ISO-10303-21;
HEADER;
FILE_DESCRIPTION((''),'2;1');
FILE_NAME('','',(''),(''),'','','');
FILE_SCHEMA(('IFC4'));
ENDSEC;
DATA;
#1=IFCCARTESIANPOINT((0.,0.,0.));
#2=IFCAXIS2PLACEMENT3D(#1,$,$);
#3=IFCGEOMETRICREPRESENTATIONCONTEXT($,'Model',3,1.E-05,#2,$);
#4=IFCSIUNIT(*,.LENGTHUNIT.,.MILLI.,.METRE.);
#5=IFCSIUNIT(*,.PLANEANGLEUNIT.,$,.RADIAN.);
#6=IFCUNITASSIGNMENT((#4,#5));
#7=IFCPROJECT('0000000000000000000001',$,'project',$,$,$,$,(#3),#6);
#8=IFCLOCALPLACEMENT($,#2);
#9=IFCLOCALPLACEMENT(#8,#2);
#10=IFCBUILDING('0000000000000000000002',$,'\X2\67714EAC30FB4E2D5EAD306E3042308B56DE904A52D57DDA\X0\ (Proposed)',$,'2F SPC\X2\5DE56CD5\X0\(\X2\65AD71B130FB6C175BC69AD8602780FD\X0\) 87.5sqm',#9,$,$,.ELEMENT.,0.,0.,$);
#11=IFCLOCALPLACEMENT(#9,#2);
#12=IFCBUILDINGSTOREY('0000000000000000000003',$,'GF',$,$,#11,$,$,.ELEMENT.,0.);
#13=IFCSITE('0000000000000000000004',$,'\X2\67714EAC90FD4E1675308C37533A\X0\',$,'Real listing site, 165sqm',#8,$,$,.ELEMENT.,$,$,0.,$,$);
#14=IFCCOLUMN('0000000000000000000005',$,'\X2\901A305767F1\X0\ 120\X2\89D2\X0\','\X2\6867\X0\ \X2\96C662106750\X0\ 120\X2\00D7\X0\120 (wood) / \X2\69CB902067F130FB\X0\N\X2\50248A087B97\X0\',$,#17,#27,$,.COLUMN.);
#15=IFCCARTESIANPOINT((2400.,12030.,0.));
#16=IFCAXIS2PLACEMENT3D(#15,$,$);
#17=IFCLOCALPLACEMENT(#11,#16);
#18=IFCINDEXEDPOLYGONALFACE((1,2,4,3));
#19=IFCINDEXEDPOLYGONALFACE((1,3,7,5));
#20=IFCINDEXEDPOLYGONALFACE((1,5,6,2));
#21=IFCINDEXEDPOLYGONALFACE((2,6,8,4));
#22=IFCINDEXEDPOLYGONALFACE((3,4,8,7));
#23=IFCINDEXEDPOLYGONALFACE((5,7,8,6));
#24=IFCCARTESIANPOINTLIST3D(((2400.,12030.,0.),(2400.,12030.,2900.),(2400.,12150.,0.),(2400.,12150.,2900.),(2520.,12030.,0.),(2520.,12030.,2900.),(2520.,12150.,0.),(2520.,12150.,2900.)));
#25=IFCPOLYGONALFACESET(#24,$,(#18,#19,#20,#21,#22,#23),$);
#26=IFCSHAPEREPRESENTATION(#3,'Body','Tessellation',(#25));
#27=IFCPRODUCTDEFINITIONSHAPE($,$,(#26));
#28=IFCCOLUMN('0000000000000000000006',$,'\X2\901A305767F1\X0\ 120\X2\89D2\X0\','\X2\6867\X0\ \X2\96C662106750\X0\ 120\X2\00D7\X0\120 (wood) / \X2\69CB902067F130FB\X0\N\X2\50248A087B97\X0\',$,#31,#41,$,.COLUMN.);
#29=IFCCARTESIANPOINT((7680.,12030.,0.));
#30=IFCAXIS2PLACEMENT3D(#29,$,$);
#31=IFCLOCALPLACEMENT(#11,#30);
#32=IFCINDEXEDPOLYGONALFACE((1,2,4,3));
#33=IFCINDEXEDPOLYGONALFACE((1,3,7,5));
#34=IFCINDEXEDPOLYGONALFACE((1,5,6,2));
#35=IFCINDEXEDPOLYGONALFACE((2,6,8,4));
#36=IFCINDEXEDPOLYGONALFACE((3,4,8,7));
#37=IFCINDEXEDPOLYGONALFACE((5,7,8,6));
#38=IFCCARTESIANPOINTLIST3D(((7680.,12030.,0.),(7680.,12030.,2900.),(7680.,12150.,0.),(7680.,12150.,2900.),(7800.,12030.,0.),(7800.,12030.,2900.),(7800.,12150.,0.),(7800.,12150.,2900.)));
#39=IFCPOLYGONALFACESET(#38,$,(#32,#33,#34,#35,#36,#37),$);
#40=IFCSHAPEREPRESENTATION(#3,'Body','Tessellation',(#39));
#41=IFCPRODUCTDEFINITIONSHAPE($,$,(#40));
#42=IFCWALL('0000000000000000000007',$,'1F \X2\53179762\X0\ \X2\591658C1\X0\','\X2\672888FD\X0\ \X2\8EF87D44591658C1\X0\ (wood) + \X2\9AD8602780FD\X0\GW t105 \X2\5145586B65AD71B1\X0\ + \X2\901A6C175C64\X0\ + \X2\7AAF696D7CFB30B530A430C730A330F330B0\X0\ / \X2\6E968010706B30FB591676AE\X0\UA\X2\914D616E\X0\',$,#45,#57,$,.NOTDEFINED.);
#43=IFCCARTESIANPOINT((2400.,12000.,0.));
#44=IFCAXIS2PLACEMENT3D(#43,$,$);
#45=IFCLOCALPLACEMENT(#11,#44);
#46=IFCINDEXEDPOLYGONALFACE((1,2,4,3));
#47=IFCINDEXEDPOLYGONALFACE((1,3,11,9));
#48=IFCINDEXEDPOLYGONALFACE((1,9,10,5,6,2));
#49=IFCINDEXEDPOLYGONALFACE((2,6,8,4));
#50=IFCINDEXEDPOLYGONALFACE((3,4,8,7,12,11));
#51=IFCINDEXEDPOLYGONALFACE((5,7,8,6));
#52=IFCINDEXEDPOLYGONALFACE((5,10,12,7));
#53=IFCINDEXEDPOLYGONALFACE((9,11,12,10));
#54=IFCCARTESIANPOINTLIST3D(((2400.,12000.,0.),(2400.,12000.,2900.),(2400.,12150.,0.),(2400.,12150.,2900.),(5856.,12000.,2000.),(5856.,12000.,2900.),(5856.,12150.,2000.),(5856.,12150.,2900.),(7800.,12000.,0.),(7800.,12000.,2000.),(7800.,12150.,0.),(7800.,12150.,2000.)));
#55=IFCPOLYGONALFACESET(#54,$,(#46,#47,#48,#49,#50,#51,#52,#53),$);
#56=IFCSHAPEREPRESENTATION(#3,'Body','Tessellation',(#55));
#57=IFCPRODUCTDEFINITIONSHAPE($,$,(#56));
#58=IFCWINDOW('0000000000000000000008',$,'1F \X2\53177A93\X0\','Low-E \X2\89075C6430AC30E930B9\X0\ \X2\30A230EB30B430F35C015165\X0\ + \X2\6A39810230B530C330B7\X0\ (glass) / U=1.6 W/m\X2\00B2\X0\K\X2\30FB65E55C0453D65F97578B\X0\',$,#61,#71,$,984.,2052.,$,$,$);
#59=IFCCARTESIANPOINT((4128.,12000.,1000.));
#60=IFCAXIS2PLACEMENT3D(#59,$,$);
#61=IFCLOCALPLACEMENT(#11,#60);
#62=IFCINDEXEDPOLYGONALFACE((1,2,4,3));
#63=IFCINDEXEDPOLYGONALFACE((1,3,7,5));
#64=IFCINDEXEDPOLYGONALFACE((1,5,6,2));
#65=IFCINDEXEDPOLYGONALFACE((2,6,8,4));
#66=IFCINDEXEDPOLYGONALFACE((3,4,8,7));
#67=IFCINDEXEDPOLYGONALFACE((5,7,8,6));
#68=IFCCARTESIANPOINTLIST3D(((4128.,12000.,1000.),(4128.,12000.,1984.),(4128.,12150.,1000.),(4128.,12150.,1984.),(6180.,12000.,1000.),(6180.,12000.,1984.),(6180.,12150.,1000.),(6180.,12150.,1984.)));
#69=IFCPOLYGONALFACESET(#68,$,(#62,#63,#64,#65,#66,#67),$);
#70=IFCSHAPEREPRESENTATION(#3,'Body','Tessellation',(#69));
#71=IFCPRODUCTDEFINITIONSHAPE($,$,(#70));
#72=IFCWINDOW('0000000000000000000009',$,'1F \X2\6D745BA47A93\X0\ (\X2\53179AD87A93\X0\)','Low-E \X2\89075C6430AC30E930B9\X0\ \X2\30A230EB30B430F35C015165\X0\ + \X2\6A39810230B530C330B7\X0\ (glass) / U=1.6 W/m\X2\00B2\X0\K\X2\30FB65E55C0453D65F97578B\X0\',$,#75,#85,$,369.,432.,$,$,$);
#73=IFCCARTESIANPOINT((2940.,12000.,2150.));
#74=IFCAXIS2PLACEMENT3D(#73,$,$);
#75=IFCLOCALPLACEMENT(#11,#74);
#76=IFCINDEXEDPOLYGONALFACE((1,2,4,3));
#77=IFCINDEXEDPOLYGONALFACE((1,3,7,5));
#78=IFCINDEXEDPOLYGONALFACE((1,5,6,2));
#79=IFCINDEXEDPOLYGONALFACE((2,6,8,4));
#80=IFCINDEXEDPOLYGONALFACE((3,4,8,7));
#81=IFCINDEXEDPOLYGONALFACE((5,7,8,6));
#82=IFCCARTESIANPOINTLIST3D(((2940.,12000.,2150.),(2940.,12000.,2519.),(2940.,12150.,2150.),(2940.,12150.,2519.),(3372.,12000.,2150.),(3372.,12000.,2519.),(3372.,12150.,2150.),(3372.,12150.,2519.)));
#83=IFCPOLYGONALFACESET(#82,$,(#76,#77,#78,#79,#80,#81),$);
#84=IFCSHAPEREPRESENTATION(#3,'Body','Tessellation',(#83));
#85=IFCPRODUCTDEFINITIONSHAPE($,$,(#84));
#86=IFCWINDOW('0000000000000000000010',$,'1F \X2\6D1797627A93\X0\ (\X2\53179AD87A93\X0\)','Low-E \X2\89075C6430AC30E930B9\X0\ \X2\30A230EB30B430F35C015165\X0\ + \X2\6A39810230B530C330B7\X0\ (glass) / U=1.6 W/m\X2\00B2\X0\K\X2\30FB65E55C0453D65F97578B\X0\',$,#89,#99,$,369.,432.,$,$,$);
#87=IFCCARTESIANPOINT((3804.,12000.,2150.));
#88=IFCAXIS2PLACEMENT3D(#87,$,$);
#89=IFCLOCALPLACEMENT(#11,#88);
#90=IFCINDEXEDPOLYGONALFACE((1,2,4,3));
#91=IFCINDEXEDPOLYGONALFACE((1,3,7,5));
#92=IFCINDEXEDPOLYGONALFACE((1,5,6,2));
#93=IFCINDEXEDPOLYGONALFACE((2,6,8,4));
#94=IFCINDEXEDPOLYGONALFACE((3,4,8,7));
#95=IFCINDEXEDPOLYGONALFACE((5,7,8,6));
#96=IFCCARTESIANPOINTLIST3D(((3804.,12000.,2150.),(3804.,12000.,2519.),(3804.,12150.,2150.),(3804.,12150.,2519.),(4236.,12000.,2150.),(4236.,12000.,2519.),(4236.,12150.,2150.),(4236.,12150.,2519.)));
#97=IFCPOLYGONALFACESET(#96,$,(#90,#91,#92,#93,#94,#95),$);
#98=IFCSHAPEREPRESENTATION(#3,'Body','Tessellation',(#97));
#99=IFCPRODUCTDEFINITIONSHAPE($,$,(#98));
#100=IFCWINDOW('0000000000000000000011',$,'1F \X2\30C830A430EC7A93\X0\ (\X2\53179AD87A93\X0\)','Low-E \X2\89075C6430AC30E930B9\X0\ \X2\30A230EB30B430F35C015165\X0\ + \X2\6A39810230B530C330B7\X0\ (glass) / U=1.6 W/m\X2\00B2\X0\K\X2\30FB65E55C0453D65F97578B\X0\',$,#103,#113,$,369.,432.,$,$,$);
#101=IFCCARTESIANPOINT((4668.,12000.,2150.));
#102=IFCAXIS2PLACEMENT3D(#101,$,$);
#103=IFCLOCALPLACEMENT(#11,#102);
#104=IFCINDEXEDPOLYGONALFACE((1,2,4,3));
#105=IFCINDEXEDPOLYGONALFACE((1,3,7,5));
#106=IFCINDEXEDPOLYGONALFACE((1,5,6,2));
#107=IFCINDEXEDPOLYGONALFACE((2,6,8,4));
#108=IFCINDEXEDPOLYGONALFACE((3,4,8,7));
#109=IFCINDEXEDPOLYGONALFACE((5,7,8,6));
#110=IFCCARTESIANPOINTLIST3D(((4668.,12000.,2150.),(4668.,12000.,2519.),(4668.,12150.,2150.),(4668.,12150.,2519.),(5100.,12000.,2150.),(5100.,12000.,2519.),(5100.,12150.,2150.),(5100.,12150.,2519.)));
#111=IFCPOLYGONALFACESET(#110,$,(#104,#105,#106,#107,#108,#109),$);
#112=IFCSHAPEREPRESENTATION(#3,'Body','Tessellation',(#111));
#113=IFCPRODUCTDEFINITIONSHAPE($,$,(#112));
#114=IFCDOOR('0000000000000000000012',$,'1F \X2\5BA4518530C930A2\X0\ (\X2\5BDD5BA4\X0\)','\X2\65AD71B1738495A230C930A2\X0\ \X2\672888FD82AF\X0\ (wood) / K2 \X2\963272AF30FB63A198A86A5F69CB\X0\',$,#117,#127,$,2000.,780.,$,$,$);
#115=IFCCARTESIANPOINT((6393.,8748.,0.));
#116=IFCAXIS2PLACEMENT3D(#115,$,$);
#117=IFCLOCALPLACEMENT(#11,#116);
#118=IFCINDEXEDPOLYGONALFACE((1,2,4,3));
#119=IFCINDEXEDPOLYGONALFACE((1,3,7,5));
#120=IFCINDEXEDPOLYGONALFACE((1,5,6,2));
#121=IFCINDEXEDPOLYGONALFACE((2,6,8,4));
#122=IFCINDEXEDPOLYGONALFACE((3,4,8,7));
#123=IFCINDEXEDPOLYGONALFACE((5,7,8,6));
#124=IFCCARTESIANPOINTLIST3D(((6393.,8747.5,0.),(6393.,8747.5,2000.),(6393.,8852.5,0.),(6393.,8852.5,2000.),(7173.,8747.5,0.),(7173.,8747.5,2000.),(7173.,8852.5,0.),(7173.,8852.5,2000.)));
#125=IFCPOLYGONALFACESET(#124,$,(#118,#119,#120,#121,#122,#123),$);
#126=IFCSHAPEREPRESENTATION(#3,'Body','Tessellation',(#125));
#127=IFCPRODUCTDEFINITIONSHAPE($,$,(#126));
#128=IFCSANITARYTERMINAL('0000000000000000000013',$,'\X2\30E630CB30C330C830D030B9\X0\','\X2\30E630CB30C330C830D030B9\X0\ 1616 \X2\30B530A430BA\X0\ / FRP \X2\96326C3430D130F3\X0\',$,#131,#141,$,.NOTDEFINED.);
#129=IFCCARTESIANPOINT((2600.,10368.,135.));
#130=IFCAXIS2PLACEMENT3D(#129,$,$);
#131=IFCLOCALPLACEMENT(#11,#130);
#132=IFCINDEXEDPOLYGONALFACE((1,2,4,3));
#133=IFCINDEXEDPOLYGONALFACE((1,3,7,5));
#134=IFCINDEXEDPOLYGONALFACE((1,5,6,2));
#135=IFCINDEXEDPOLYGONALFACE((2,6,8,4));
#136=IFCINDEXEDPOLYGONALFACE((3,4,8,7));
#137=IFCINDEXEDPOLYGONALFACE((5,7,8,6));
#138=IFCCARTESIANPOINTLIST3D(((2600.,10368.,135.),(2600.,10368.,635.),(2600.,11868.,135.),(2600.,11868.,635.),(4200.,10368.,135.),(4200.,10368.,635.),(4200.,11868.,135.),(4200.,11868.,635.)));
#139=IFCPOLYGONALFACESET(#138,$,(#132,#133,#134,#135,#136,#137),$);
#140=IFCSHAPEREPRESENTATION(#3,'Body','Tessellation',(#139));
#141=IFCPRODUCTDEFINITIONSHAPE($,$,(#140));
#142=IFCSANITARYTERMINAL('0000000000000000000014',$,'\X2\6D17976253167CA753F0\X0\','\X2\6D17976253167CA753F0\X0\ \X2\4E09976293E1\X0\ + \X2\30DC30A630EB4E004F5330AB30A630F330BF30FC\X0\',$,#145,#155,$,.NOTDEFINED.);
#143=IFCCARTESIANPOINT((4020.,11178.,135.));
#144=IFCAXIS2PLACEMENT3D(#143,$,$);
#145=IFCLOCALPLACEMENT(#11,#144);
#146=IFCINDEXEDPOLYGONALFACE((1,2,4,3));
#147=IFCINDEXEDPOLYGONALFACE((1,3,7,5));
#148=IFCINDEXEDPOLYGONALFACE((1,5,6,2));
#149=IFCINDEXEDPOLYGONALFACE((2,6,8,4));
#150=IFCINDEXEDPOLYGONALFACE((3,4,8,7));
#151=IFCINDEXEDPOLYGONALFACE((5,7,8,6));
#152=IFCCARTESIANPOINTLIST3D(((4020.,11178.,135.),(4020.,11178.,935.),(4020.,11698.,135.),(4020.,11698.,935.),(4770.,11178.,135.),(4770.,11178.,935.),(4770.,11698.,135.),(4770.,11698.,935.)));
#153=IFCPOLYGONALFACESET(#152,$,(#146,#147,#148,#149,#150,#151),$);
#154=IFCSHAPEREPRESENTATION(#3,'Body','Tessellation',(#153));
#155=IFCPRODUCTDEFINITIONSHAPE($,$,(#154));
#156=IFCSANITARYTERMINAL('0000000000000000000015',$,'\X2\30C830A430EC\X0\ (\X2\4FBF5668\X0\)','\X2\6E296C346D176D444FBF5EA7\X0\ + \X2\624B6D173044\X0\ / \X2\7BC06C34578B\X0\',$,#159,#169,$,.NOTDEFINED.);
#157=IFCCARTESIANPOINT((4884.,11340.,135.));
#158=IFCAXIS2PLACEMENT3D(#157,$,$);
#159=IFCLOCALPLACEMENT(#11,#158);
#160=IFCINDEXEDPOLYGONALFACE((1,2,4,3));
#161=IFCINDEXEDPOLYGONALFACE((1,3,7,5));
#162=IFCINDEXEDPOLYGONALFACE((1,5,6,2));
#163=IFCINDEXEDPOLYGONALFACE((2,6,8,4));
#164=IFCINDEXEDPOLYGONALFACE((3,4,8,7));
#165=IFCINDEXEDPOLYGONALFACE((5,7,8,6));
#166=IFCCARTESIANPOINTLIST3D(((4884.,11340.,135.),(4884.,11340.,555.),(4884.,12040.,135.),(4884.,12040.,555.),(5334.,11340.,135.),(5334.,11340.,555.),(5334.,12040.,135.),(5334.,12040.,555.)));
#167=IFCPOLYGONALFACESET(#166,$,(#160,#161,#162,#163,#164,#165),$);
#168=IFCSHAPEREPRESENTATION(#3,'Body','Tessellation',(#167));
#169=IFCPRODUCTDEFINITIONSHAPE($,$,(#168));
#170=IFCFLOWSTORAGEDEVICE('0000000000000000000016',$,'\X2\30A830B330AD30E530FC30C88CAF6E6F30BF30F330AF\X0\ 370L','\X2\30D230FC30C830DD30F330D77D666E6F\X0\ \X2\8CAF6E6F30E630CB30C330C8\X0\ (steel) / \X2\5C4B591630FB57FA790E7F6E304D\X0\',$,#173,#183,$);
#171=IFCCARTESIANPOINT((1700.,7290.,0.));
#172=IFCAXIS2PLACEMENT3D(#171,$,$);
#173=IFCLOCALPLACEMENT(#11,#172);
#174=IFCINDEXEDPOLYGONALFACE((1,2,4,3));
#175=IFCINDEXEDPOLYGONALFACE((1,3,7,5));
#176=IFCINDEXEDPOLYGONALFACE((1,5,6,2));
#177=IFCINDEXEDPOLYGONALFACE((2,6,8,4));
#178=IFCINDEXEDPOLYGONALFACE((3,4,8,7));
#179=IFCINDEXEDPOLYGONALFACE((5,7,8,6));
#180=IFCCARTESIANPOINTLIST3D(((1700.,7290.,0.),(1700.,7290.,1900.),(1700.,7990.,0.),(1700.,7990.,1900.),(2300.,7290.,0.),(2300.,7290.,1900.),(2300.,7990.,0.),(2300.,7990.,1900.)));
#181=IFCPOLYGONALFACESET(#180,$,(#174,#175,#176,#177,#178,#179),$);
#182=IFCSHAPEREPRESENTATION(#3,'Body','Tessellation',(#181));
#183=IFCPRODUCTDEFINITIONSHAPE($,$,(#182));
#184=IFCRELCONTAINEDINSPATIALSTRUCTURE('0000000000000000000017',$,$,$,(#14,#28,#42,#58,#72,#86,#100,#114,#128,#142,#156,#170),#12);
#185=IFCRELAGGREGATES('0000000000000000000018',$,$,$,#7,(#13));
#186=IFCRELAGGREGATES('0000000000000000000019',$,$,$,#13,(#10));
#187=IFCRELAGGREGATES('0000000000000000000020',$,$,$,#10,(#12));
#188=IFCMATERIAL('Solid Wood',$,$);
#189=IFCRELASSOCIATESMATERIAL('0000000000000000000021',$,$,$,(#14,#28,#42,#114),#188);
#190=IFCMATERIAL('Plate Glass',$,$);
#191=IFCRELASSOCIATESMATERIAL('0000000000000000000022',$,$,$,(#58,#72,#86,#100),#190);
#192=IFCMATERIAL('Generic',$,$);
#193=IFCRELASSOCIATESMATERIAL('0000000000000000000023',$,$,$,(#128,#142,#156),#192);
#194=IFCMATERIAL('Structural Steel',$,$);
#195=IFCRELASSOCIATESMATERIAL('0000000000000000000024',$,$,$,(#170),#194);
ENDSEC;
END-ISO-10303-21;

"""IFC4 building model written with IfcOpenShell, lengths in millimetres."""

from ifc_helpers import new_model, si_unit, frame, frame_2d, origin, place, context, project, spatial, rectangle, extrude, material, element, fill, save


model = new_model("IFC4")

# Units and contexts
model_context = context("Model", 3, precision=1e-05, world=origin())
ifc_project = project(units=[si_unit("LENGTHUNIT", "METRE", prefix="MILLI"), si_unit("PLANEANGLEUNIT", "RADIAN")], contexts=[model_context])

# Site, building, storey
site_placement = place(None, origin())
site = spatial("IfcSite", under=ifc_project, at=site_placement, Name="東京都世田谷区", ObjectType="Real listing site, 165sqm", CompositionType="ELEMENT", RefElevation=0.0)
building_placement = place(site_placement, origin())
building = spatial("IfcBuilding", under=site, at=building_placement, Name="東京・中庭のある回遊動線 (Proposed)", ObjectType="2F SPC工法(断熱・気密高性能) 87.5sqm", CompositionType="ELEMENT", ElevationOfRefHeight=0.0, ElevationOfTerrain=0.0)
storey_placement = place(building_placement, origin())
storey = spatial("IfcBuildingStorey", under=building, at=storey_placement, Name="GF", CompositionType="ELEMENT", Elevation=0.0)

# Columns
ifc_material_1 = material(Name="Solid Wood")
column_1_placement = place(storey_placement, frame((2400.0, 12030.0, 0.0)))
element("IfcColumn", 1, at=column_1_placement, inside=storey, material=ifc_material_1, Name="通し柱 120角", Description="桧 集成材 120×120 (wood) / 構造柱・N値計算", PredefinedType="COLUMN", context=model_context, shape_type="SweptSolid", body=[
    extrude(rectangle(XDim=120.0, YDim=120.0, at=frame_2d((60.0, 60.0))), frame((2400.0, 12030.0, 0.0)), (0.0, 0.0, 1.0), 2900.0),
])
column_2_placement = place(storey_placement, frame((7680.0, 12030.0, 0.0)))
element("IfcColumn", 2, at=column_2_placement, inside=storey, material=ifc_material_1, Name="通し柱 120角", Description="桧 集成材 120×120 (wood) / 構造柱・N値計算", PredefinedType="COLUMN", context=model_context, shape_type="SweptSolid", body=[
    extrude(rectangle(XDim=120.0, YDim=120.0, at=frame_2d((60.0, 60.0))), frame((7680.0, 12030.0, 0.0)), (0.0, 0.0, 1.0), 2900.0),
])

# Wall, openings, windows
wall_1_placement = place(storey_placement, frame((2400.0, 12000.0, 0.0)))
wall_1 = element("IfcWall", 3, at=wall_1_placement, inside=storey, material=ifc_material_1, Name="1F 北面 外壁", Description="木製 軸組外壁 (wood) + 高性能GW t105 充填断熱 + 通気層 + 窯業系サイディング / 準耐火・外皮UA配慮", PredefinedType="NOTDEFINED", context=model_context, shape_type="SweptSolid", body=[
    extrude(rectangle(XDim=5400.0, YDim=150.0, at=frame_2d((2700.0, 75.0))), frame((2400.0, 12000.0, 0.0)), (0.0, 0.0, 1.0), 2900.0),
])
opening_1_placement = place(storey_placement, frame((4128.0, 12000.0, 1000.0)))
opening_1 = element("IfcOpeningElement", 4, at=opening_1_placement, cuts=wall_1, PredefinedType="NOTDEFINED", context=model_context, shape_type="SweptSolid", body=[
    extrude(rectangle(XDim=2052.0, YDim=150.0, at=frame_2d((1026.0, 75.0))), frame((4128.0, 12000.0, 1000.0)), (0.0, 0.0, 1.0), 984.0),
])
opening_2_placement = place(storey_placement, frame((2940.0, 12000.0, 2150.0)))
opening_2 = element("IfcOpeningElement", 5, at=opening_2_placement, cuts=wall_1, PredefinedType="NOTDEFINED", context=model_context, shape_type="SweptSolid", body=[
    extrude(rectangle(XDim=432.0, YDim=150.0, at=frame_2d((216.0, 75.0))), frame((2940.0, 12000.0, 2150.0)), (0.0, 0.0, 1.0), 369.0),
])
opening_3_placement = place(storey_placement, frame((3804.0, 12000.0, 2150.0)))
opening_3 = element("IfcOpeningElement", 6, at=opening_3_placement, cuts=wall_1, PredefinedType="NOTDEFINED", context=model_context, shape_type="SweptSolid", body=[
    extrude(rectangle(XDim=432.0, YDim=150.0, at=frame_2d((216.0, 75.0))), frame((3804.0, 12000.0, 2150.0)), (0.0, 0.0, 1.0), 369.0),
])
opening_4_placement = place(storey_placement, frame((4668.0, 12000.0, 2150.0)))
opening_4 = element("IfcOpeningElement", 7, at=opening_4_placement, cuts=wall_1, PredefinedType="NOTDEFINED", context=model_context, shape_type="SweptSolid", body=[
    extrude(rectangle(XDim=432.0, YDim=150.0, at=frame_2d((216.0, 75.0))), frame((4668.0, 12000.0, 2150.0)), (0.0, 0.0, 1.0), 369.0),
])
ifc_material_2 = material(Name="Plate Glass")
window_1_placement = place(storey_placement, frame((4128.0, 12000.0, 1000.0)))
window_1 = element("IfcWindow", 8, at=window_1_placement, inside=storey, material=ifc_material_2, Name="1F 北窓", Description="Low-E 複層ガラス アルゴン封入 + 樹脂サッシ (glass) / U=1.6 W/m²K・日射取得型", OverallHeight=984.0, OverallWidth=2052.0, context=model_context, shape_type="SweptSolid", body=[
    extrude(rectangle(XDim=2052.0, YDim=150.0, at=frame_2d((1026.0, 75.0))), frame((4128.0, 12000.0, 1000.0)), (0.0, 0.0, 1.0), 984.0),
])
fill(opening_1, window_1)
window_2_placement = place(storey_placement, frame((2940.0, 12000.0, 2150.0)))
window_2 = element("IfcWindow", 9, at=window_2_placement, inside=storey, material=ifc_material_2, Name="1F 浴室窓 (北高窓)", Description="Low-E 複層ガラス アルゴン封入 + 樹脂サッシ (glass) / U=1.6 W/m²K・日射取得型", OverallHeight=369.0, OverallWidth=432.0, context=model_context, shape_type="SweptSolid", body=[
    extrude(rectangle(XDim=432.0, YDim=150.0, at=frame_2d((216.0, 75.0))), frame((2940.0, 12000.0, 2150.0)), (0.0, 0.0, 1.0), 369.0),
])
fill(opening_2, window_2)
window_3_placement = place(storey_placement, frame((3804.0, 12000.0, 2150.0)))
window_3 = element("IfcWindow", 10, at=window_3_placement, inside=storey, material=ifc_material_2, Name="1F 洗面窓 (北高窓)", Description="Low-E 複層ガラス アルゴン封入 + 樹脂サッシ (glass) / U=1.6 W/m²K・日射取得型", OverallHeight=369.0, OverallWidth=432.0, context=model_context, shape_type="SweptSolid", body=[
    extrude(rectangle(XDim=432.0, YDim=150.0, at=frame_2d((216.0, 75.0))), frame((3804.0, 12000.0, 2150.0)), (0.0, 0.0, 1.0), 369.0),
])
fill(opening_3, window_3)
window_4_placement = place(storey_placement, frame((4668.0, 12000.0, 2150.0)))
window_4 = element("IfcWindow", 11, at=window_4_placement, inside=storey, material=ifc_material_2, Name="1F トイレ窓 (北高窓)", Description="Low-E 複層ガラス アルゴン封入 + 樹脂サッシ (glass) / U=1.6 W/m²K・日射取得型", OverallHeight=369.0, OverallWidth=432.0, context=model_context, shape_type="SweptSolid", body=[
    extrude(rectangle(XDim=432.0, YDim=150.0, at=frame_2d((216.0, 75.0))), frame((4668.0, 12000.0, 2150.0)), (0.0, 0.0, 1.0), 369.0),
])
fill(opening_4, window_4)

# Door
door_1_placement = place(storey_placement, frame((6393.0, 8748.0, 0.0)))
element("IfcDoor", 12, at=door_1_placement, inside=storey, material=ifc_material_1, Name="1F 室内ドア (寝室)", Description="断熱玄関ドア 木製芯 (wood) / K2 防犯・採風機構", OverallHeight=2000.0, OverallWidth=780.0, context=model_context, shape_type="SweptSolid", body=[
    extrude(rectangle(XDim=780.0, YDim=105.0, at=frame_2d((390.0, 52.0))), frame((6393.0, 8748.0, 0.0)), (0.0, 0.0, 1.0), 2000.0),
])

# Sanitary terminals
ifc_material_3 = material(Name="Generic")
sanitary_terminal_1_placement = place(storey_placement, frame((2600.0, 10368.0, 135.0)))
element("IfcSanitaryTerminal", 13, at=sanitary_terminal_1_placement, inside=storey, material=ifc_material_3, Name="ユニットバス", Description="ユニットバス 1616 サイズ / FRP 防水パン", PredefinedType="NOTDEFINED", context=model_context, shape_type="SweptSolid", body=[
    extrude(rectangle(XDim=1600.0, YDim=1500.0, at=frame_2d((800.0, 750.0))), frame((2600.0, 10368.0, 135.0)), (0.0, 0.0, 1.0), 500.0),
])
sanitary_terminal_2_placement = place(storey_placement, frame((4020.0, 11178.0, 135.0)))
element("IfcSanitaryTerminal", 14, at=sanitary_terminal_2_placement, inside=storey, material=ifc_material_3, Name="洗面化粧台", Description="洗面化粧台 三面鏡 + ボウル一体カウンター", PredefinedType="NOTDEFINED", context=model_context, shape_type="SweptSolid", body=[
    extrude(rectangle(XDim=750.0, YDim=520.0, at=frame_2d((375.0, 260.0))), frame((4020.0, 11178.0, 135.0)), (0.0, 0.0, 1.0), 800.0),
])
sanitary_terminal_3_placement = place(storey_placement, frame((4884.0, 11340.0, 135.0)))
element("IfcSanitaryTerminal", 15, at=sanitary_terminal_3_placement, inside=storey, material=ifc_material_3, Name="トイレ (便器)", Description="温水洗浄便座 + 手洗い / 節水型", PredefinedType="NOTDEFINED", context=model_context, shape_type="SweptSolid", body=[
    extrude(rectangle(XDim=450.0, YDim=700.0, at=frame_2d((225.0, 350.0))), frame((4884.0, 11340.0, 135.0)), (0.0, 0.0, 1.0), 420.0),
])

# Flow storage device
ifc_material_4 = material(Name="Structural Steel")
flow_storage_device_placement = place(storey_placement, frame((1700.0, 7290.0, 0.0)))
element("IfcFlowStorageDevice", 16, at=flow_storage_device_placement, inside=storey, material=ifc_material_4, Name="エコキュート貯湯タンク 370L", Description="ヒートポンプ給湯 貯湯ユニット (steel) / 屋外・基礎置き", context=model_context, shape_type="SweptSolid", body=[
    extrude(rectangle(XDim=600.0, YDim=700.0, at=frame_2d((300.0, 350.0))), frame((1700.0, 7290.0, 0.0)), (0.0, 0.0, 1.0), 1900.0),
])

save(model, "model.ifc")
